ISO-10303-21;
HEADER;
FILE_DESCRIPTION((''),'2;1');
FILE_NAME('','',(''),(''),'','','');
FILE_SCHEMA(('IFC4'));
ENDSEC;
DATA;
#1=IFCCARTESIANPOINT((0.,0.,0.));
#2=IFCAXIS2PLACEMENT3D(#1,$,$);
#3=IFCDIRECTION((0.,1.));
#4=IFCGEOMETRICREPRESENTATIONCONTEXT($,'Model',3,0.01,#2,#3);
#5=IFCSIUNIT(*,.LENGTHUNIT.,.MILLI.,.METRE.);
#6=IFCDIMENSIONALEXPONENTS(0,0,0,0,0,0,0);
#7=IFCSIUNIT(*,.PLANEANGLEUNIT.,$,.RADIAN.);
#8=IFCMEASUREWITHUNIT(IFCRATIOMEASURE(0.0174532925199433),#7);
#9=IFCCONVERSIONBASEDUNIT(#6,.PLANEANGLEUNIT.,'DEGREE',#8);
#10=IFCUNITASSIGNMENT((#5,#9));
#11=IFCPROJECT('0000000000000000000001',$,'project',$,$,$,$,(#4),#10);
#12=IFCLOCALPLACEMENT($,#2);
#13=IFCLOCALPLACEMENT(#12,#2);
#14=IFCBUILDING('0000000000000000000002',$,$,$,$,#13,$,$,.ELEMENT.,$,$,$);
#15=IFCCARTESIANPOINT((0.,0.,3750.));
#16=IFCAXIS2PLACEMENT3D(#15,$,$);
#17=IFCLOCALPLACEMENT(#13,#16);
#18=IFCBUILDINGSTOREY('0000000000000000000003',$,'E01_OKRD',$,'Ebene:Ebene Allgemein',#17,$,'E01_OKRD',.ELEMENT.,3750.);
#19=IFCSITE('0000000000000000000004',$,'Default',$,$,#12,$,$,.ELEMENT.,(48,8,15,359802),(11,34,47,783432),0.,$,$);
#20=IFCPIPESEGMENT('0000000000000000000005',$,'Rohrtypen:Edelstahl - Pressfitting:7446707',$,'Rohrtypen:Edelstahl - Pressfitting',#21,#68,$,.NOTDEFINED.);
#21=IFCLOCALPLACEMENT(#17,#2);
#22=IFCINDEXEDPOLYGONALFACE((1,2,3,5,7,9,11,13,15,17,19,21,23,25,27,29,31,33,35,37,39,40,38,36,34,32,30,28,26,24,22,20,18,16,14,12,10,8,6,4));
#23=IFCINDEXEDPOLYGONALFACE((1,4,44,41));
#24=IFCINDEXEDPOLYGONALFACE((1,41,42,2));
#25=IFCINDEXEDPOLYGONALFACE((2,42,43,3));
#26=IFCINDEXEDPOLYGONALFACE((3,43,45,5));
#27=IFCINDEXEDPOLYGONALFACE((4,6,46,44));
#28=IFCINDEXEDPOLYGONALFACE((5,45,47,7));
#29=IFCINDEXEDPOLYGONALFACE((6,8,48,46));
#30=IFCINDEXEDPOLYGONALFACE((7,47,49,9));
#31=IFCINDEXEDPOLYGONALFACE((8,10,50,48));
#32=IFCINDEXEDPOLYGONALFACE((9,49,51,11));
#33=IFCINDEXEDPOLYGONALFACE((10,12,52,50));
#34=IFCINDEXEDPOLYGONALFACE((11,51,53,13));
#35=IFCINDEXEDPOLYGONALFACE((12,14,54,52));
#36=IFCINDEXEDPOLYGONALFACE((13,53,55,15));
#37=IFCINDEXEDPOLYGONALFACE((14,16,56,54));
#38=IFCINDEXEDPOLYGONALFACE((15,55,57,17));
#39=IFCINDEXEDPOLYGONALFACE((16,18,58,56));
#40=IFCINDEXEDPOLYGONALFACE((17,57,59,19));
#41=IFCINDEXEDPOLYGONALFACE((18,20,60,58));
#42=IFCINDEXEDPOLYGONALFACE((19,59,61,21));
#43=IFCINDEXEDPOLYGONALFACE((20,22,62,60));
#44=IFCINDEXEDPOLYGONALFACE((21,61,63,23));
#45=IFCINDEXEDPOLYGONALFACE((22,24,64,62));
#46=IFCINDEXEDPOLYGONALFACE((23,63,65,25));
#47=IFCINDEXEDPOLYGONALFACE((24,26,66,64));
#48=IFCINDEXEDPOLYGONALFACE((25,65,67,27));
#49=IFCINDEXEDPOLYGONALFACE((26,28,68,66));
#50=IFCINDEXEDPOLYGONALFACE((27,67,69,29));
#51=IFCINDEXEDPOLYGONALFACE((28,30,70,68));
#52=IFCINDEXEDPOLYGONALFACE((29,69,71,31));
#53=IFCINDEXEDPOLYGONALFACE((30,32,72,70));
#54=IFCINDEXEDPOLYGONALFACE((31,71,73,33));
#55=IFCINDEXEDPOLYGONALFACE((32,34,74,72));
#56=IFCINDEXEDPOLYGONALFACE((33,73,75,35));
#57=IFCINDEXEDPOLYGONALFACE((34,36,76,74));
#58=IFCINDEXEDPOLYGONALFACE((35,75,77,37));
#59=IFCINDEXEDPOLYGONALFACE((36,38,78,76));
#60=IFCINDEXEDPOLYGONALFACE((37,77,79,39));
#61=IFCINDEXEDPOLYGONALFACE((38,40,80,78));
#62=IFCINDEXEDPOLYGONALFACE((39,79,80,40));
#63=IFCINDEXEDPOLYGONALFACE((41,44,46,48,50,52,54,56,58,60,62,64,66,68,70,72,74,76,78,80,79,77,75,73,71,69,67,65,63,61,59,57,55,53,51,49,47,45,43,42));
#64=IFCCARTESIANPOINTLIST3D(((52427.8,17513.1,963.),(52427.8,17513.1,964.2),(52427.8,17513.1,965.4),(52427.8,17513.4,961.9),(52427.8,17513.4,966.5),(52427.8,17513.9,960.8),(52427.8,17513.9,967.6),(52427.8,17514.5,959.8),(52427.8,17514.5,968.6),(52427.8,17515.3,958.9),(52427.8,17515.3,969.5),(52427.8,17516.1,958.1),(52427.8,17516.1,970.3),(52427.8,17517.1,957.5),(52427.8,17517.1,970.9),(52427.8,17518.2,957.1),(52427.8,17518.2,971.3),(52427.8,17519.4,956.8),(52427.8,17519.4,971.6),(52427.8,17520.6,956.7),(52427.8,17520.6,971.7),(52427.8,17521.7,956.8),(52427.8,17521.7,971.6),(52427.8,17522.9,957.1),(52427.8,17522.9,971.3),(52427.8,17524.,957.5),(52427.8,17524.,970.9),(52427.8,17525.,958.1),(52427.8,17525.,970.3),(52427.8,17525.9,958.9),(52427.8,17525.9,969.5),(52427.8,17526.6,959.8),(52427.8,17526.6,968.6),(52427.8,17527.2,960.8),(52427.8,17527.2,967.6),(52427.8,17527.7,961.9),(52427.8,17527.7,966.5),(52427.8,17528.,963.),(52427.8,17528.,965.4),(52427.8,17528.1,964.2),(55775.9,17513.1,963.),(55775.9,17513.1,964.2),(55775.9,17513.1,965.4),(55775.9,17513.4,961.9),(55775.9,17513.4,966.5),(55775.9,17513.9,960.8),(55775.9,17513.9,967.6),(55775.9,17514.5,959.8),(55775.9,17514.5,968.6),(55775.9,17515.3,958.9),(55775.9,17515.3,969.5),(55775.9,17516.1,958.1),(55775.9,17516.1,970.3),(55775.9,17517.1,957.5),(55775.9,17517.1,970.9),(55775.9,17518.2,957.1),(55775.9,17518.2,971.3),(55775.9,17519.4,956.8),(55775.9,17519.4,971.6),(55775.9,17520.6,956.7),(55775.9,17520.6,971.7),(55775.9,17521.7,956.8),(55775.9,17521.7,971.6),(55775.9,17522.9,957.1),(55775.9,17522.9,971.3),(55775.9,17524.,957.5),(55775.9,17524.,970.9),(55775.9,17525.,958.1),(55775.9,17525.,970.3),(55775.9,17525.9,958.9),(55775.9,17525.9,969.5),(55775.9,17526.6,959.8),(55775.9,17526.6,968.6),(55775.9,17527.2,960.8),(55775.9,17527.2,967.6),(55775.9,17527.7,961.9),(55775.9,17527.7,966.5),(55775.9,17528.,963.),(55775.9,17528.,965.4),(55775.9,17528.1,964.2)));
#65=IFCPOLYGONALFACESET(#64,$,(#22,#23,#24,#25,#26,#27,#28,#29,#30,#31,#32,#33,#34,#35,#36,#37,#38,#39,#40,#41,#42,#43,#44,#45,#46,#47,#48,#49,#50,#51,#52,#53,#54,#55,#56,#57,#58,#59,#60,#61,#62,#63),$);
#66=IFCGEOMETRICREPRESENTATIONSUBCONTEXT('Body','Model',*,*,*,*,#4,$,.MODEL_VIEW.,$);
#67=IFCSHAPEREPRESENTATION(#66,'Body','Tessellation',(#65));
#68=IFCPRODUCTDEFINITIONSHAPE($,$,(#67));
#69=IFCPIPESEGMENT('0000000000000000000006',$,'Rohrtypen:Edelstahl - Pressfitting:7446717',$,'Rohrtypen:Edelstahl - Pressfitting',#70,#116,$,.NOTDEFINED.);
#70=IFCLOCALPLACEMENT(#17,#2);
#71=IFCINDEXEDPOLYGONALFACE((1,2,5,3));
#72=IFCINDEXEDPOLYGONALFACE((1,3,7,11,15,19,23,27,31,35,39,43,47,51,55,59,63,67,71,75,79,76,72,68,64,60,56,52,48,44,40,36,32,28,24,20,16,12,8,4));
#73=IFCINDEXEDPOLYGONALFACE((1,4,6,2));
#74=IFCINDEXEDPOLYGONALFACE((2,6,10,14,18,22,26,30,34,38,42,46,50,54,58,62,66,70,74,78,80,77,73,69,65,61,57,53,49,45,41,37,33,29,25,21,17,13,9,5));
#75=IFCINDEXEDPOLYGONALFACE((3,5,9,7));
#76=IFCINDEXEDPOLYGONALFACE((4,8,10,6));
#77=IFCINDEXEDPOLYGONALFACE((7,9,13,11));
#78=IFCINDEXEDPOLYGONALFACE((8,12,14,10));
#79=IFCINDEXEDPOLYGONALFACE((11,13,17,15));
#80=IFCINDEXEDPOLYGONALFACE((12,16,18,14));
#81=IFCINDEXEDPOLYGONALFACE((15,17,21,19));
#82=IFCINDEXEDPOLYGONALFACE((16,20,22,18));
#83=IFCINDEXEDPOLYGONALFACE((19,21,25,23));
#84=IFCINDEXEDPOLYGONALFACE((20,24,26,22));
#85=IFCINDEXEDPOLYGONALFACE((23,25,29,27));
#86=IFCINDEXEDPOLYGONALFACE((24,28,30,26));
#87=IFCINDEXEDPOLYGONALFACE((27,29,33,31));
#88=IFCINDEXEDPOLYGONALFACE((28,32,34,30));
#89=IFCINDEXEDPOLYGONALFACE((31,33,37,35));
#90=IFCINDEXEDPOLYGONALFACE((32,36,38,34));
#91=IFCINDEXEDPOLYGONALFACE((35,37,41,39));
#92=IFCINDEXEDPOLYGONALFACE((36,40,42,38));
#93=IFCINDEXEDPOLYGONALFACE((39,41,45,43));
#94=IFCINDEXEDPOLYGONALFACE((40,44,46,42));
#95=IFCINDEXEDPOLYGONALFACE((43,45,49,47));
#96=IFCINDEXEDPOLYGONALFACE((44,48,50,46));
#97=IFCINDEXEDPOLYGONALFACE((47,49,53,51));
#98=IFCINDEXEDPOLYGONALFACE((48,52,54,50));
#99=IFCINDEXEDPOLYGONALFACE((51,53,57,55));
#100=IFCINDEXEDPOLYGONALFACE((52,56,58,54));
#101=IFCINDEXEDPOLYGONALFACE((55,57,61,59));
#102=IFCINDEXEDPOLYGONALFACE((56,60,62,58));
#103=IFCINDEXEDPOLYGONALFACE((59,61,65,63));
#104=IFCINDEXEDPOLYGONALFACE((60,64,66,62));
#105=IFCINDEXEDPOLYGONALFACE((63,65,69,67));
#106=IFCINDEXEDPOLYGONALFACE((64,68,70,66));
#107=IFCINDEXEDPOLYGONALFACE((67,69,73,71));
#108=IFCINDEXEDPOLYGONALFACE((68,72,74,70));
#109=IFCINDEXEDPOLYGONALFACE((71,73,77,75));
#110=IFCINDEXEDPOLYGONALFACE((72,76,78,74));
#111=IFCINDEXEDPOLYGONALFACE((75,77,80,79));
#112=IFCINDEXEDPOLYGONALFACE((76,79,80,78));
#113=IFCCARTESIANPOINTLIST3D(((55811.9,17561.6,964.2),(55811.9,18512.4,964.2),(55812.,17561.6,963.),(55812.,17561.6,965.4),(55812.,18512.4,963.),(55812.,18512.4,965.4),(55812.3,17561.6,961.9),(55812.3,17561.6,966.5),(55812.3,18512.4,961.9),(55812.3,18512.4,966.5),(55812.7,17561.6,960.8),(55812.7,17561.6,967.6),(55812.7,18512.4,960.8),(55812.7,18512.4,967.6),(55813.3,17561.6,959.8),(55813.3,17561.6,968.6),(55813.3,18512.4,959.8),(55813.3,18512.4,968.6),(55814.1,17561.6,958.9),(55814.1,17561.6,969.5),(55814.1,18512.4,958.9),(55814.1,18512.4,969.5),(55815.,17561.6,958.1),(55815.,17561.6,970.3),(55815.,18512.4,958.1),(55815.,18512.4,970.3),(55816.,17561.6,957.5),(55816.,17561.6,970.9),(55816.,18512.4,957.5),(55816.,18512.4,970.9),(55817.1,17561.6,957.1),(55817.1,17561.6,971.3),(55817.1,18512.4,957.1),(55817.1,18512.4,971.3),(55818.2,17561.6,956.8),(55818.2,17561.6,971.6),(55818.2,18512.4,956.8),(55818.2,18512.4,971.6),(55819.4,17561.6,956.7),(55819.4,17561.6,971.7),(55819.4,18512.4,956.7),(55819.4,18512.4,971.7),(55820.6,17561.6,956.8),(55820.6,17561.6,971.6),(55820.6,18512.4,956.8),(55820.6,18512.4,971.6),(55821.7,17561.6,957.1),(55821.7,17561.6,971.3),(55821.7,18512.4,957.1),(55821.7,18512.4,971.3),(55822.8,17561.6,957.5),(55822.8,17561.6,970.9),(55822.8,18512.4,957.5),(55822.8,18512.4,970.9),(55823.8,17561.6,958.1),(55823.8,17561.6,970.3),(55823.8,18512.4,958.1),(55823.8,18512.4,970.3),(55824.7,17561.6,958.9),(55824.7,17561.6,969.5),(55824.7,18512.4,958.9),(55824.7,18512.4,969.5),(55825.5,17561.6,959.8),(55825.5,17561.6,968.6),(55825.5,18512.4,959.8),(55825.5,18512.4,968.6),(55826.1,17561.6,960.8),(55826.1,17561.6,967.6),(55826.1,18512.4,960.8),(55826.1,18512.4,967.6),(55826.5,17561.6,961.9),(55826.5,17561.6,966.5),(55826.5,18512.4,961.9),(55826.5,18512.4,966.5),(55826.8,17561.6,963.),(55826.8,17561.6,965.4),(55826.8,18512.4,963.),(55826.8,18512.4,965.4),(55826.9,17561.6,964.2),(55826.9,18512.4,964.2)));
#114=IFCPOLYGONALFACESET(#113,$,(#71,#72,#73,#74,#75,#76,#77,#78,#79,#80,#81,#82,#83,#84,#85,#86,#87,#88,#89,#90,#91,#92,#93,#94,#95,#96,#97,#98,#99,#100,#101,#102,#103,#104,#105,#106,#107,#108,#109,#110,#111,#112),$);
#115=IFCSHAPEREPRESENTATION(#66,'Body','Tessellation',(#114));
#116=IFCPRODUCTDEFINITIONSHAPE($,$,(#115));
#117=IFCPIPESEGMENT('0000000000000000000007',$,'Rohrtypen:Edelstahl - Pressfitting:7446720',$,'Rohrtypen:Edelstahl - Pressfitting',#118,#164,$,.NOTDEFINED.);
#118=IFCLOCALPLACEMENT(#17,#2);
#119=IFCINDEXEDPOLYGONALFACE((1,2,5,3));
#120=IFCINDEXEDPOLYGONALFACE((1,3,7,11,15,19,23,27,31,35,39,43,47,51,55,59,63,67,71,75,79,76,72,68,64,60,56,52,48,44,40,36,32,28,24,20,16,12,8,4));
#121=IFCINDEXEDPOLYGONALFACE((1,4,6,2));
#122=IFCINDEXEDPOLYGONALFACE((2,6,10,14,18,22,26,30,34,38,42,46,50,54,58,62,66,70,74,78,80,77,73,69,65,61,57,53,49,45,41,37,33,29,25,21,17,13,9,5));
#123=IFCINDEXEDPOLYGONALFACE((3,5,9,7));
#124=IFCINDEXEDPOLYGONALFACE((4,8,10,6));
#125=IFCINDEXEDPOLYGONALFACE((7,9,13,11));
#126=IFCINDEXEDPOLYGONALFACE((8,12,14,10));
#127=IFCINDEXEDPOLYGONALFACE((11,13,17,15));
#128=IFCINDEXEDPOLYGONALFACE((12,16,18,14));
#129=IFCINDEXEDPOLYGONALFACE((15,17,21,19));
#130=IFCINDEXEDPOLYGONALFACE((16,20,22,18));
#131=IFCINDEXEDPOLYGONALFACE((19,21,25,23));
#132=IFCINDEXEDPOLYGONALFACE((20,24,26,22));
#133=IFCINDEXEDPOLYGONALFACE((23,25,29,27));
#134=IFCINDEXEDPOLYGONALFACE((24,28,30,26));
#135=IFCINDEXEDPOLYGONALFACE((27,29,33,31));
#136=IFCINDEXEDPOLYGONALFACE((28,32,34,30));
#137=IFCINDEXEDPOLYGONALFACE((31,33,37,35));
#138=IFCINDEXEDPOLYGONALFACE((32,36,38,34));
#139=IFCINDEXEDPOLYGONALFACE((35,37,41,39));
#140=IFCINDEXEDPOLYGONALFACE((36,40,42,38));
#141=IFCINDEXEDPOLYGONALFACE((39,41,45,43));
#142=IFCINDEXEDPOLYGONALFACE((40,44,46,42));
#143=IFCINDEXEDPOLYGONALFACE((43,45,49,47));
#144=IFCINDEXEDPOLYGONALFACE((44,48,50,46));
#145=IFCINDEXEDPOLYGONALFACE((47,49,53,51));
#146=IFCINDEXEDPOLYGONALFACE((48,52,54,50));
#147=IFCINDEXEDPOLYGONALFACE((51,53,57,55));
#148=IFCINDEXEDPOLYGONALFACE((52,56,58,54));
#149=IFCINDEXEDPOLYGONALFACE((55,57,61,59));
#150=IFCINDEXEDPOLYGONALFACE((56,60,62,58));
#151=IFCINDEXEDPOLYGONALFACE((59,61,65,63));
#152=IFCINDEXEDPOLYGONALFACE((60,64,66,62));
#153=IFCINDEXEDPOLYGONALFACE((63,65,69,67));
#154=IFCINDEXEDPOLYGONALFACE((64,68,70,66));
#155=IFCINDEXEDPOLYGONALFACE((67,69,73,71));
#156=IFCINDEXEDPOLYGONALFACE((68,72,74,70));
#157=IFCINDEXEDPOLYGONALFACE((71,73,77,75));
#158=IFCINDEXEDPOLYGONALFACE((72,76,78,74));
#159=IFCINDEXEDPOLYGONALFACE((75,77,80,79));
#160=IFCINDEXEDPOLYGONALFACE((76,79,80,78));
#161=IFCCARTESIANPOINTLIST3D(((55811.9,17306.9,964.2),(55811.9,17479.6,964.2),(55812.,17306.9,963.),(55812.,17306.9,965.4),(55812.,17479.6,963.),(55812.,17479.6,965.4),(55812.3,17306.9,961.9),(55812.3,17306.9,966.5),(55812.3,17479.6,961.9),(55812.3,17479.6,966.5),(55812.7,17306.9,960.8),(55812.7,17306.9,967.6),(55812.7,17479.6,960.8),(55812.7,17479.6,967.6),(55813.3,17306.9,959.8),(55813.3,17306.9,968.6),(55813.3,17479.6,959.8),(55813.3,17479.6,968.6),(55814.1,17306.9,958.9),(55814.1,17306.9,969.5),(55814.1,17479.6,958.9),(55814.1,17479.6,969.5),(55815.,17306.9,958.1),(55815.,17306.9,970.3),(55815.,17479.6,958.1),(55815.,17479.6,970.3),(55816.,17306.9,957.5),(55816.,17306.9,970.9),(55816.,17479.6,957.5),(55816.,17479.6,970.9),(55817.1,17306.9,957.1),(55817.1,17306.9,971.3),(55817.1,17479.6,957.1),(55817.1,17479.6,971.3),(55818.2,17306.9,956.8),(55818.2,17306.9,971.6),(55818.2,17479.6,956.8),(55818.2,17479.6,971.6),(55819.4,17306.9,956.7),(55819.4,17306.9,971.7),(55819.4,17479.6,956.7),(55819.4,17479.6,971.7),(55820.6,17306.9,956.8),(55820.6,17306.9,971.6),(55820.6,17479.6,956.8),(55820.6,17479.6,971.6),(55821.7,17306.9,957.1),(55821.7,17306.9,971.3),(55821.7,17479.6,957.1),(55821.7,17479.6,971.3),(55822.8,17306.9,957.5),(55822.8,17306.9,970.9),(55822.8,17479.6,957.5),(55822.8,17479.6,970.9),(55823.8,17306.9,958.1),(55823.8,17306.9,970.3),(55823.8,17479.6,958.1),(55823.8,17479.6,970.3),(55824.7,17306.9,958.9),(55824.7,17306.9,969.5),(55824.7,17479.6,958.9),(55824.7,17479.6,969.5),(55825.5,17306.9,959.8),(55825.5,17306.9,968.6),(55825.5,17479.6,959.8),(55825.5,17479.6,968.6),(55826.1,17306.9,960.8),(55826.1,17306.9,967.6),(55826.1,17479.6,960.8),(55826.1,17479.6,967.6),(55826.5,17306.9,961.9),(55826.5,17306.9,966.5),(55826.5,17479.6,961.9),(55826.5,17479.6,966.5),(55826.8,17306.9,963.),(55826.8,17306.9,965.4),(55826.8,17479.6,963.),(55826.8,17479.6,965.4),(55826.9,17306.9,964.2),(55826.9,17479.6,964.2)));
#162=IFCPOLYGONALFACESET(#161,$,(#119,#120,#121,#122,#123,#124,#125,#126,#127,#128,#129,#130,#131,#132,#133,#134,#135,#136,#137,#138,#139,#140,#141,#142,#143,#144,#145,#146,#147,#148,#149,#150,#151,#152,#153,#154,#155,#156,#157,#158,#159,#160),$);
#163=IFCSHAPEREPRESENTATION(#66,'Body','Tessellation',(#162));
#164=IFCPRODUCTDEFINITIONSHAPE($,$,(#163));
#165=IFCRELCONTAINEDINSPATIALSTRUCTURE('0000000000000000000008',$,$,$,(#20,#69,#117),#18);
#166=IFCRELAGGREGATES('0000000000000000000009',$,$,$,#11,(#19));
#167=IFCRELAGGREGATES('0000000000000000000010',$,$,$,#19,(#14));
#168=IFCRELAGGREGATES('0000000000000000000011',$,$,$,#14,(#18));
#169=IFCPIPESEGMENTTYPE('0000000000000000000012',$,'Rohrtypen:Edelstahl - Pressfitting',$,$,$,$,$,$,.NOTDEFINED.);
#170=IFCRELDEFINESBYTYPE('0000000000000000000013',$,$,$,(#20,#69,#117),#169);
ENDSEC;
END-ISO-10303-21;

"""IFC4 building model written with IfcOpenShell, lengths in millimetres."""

from ifc_helpers import new_model, entity, si_unit, converted_unit, direction, frame, origin, place, context, subcontext, project, spatial, indexed_curve, outline, extrude, type_object, element, save


model = new_model("IFC4")

# Units and contexts
model_context = context("Model", 3, precision=0.01, world=origin(), true_north=direction((0.0, 1.0)))
body_context = subcontext(model_context, "Body", "Model", "MODEL_VIEW")
ifc_project = project(units=[si_unit("LENGTHUNIT", "METRE", prefix="MILLI"), converted_unit("PLANEANGLEUNIT", "DEGREE", entity("IfcRatioMeasure", 0.0174532925199433), si_unit("PLANEANGLEUNIT", "RADIAN"), dimensions=[0, 0, 0, 0, 0, 0, 0])], contexts=[model_context])

# Site, building, storey
site_placement = place(None, origin())
site = spatial("IfcSite", under=ifc_project, at=site_placement, Name="Default", CompositionType="ELEMENT", RefLatitude=(48, 8, 15, 359802), RefLongitude=(11, 34, 47, 783432), RefElevation=0.0)
building_placement = place(site_placement, origin())
building = spatial("IfcBuilding", under=site, at=building_placement, CompositionType="ELEMENT")
storey_placement = place(building_placement, frame((0.0, 0.0, 3750.0)))
storey = spatial("IfcBuildingStorey", under=building, at=storey_placement, Name="E01_OKRD", ObjectType="Ebene:Ebene Allgemein", LongName="E01_OKRD", CompositionType="ELEMENT", Elevation=3750.0)

# Pipe segments
pipe_segment_type_1 = type_object("IfcPipeSegmentType", Name="Rohrtypen:Edelstahl - Pressfitting", PredefinedType="NOTDEFINED")
pipe_segment_1_placement = place(storey_placement, origin())
element("IfcPipeSegment", 1, at=pipe_segment_1_placement, inside=storey, type_object=pipe_segment_type_1, Name="Rohrtypen:Edelstahl - Pressfitting:7446707", ObjectType="Rohrtypen:Edelstahl - Pressfitting", PredefinedType="NOTDEFINED", context=body_context, shape_type="SweptSolid", body=[
    extrude(outline(indexed_curve([(7.5, 0.0), (7.4, 1.2), (7.1, 2.3), (6.7, 3.4), (6.1, 4.4), (5.3, 5.3), (4.4, 6.1), (3.4, 6.7), (2.3, 7.1), (1.2, 7.4), (0.0, 7.5), (-1.2, 7.4), (-2.3, 7.1), (-3.4, 6.7), (-4.4, 6.1), (-5.3, 5.3), (-6.1, 4.4), (-6.7, 3.4), (-7.1, 2.3), (-7.4, 1.2), (-7.5, 0.0), (-7.4, -1.2), (-7.1, -2.3), (-6.7, -3.4), (-6.1, -4.4), (-5.3, -5.3), (-4.4, -6.1), (-3.4, -6.7), (-2.3, -7.1), (-1.2, -7.4), (0.0, -7.5), (1.2, -7.4), (2.3, -7.1), (3.4, -6.7), (4.4, -6.1), (5.3, -5.3), (6.1, -4.4), (6.7, -3.4), (7.1, -2.3), (7.4, -1.2), (7.5, 0.0)], self_intersect=False)), frame((52427.8, 17520.6, 964.2), z_axis=(1.0, 0.0, -0.000003), x_axis=(0.0, -1.0, 0.0)), (0.0, 0.0, 1.0), 3348.1),
])
pipe_segment_2_placement = place(storey_placement, origin())
element("IfcPipeSegment", 2, at=pipe_segment_2_placement, inside=storey, type_object=pipe_segment_type_1, Name="Rohrtypen:Edelstahl - Pressfitting:7446717", ObjectType="Rohrtypen:Edelstahl - Pressfitting", PredefinedType="NOTDEFINED", context=body_context, shape_type="SweptSolid", body=[
    extrude(outline(indexed_curve([(7.5, 0.0), (7.4, 1.2), (7.1, 2.3), (6.7, 3.4), (6.1, 4.4), (5.3, 5.3), (4.4, 6.1), (3.4, 6.7), (2.3, 7.1), (1.2, 7.4), (0.0, 7.5), (-1.2, 7.4), (-2.3, 7.1), (-3.4, 6.7), (-4.4, 6.1), (-5.3, 5.3), (-6.1, 4.4), (-6.7, 3.4), (-7.1, 2.3), (-7.4, 1.2), (-7.5, 0.0), (-7.4, -1.2), (-7.1, -2.3), (-6.7, -3.4), (-6.1, -4.4), (-5.3, -5.3), (-4.4, -6.1), (-3.4, -6.7), (-2.3, -7.1), (-1.2, -7.4), (0.0, -7.5), (1.2, -7.4), (2.3, -7.1), (3.4, -6.7), (4.4, -6.1), (5.3, -5.3), (6.1, -4.4), (6.7, -3.4), (7.1, -2.3), (7.4, -1.2), (7.5, 0.0)], self_intersect=False)), frame((55819.4, 17561.6, 964.2), z_axis=(0.0, 1.0, 0.000011), x_axis=(1.0, 0.0, 0.0)), (0.0, 0.0, 1.0), 950.9),
])
pipe_segment_3_placement = place(storey_placement, origin())
element("IfcPipeSegment", 3, at=pipe_segment_3_placement, inside=storey, type_object=pipe_segment_type_1, Name="Rohrtypen:Edelstahl - Pressfitting:7446720", ObjectType="Rohrtypen:Edelstahl - Pressfitting", PredefinedType="NOTDEFINED", context=body_context, shape_type="SweptSolid", body=[
    extrude(outline(indexed_curve([(7.5, 0.0), (7.4, 1.2), (7.1, 2.3), (6.7, 3.4), (6.1, 4.4), (5.3, 5.3), (4.4, 6.1), (3.4, 6.7), (2.3, 7.1), (1.2, 7.4), (0.0, 7.5), (-1.2, 7.4), (-2.3, 7.1), (-3.4, 6.7), (-4.4, 6.1), (-5.3, 5.3), (-6.1, 4.4), (-6.7, 3.4), (-7.1, 2.3), (-7.4, 1.2), (-7.5, 0.0), (-7.4, -1.2), (-7.1, -2.3), (-6.7, -3.4), (-6.1, -4.4), (-5.3, -5.3), (-4.4, -6.1), (-3.4, -6.7), (-2.3, -7.1), (-1.2, -7.4), (0.0, -7.5), (1.2, -7.4), (2.3, -7.1), (3.4, -6.7), (4.4, -6.1), (5.3, -5.3), (6.1, -4.4), (6.7, -3.4), (7.1, -2.3), (7.4, -1.2), (7.5, 0.0)], self_intersect=False)), frame((55819.4, 17306.9, 964.2), z_axis=(0.0, 1.0, 0.0), x_axis=(1.0, 0.0, 0.0)), (0.0, 0.0, 1.0), 172.6),
])

save(model, "model.ifc")
